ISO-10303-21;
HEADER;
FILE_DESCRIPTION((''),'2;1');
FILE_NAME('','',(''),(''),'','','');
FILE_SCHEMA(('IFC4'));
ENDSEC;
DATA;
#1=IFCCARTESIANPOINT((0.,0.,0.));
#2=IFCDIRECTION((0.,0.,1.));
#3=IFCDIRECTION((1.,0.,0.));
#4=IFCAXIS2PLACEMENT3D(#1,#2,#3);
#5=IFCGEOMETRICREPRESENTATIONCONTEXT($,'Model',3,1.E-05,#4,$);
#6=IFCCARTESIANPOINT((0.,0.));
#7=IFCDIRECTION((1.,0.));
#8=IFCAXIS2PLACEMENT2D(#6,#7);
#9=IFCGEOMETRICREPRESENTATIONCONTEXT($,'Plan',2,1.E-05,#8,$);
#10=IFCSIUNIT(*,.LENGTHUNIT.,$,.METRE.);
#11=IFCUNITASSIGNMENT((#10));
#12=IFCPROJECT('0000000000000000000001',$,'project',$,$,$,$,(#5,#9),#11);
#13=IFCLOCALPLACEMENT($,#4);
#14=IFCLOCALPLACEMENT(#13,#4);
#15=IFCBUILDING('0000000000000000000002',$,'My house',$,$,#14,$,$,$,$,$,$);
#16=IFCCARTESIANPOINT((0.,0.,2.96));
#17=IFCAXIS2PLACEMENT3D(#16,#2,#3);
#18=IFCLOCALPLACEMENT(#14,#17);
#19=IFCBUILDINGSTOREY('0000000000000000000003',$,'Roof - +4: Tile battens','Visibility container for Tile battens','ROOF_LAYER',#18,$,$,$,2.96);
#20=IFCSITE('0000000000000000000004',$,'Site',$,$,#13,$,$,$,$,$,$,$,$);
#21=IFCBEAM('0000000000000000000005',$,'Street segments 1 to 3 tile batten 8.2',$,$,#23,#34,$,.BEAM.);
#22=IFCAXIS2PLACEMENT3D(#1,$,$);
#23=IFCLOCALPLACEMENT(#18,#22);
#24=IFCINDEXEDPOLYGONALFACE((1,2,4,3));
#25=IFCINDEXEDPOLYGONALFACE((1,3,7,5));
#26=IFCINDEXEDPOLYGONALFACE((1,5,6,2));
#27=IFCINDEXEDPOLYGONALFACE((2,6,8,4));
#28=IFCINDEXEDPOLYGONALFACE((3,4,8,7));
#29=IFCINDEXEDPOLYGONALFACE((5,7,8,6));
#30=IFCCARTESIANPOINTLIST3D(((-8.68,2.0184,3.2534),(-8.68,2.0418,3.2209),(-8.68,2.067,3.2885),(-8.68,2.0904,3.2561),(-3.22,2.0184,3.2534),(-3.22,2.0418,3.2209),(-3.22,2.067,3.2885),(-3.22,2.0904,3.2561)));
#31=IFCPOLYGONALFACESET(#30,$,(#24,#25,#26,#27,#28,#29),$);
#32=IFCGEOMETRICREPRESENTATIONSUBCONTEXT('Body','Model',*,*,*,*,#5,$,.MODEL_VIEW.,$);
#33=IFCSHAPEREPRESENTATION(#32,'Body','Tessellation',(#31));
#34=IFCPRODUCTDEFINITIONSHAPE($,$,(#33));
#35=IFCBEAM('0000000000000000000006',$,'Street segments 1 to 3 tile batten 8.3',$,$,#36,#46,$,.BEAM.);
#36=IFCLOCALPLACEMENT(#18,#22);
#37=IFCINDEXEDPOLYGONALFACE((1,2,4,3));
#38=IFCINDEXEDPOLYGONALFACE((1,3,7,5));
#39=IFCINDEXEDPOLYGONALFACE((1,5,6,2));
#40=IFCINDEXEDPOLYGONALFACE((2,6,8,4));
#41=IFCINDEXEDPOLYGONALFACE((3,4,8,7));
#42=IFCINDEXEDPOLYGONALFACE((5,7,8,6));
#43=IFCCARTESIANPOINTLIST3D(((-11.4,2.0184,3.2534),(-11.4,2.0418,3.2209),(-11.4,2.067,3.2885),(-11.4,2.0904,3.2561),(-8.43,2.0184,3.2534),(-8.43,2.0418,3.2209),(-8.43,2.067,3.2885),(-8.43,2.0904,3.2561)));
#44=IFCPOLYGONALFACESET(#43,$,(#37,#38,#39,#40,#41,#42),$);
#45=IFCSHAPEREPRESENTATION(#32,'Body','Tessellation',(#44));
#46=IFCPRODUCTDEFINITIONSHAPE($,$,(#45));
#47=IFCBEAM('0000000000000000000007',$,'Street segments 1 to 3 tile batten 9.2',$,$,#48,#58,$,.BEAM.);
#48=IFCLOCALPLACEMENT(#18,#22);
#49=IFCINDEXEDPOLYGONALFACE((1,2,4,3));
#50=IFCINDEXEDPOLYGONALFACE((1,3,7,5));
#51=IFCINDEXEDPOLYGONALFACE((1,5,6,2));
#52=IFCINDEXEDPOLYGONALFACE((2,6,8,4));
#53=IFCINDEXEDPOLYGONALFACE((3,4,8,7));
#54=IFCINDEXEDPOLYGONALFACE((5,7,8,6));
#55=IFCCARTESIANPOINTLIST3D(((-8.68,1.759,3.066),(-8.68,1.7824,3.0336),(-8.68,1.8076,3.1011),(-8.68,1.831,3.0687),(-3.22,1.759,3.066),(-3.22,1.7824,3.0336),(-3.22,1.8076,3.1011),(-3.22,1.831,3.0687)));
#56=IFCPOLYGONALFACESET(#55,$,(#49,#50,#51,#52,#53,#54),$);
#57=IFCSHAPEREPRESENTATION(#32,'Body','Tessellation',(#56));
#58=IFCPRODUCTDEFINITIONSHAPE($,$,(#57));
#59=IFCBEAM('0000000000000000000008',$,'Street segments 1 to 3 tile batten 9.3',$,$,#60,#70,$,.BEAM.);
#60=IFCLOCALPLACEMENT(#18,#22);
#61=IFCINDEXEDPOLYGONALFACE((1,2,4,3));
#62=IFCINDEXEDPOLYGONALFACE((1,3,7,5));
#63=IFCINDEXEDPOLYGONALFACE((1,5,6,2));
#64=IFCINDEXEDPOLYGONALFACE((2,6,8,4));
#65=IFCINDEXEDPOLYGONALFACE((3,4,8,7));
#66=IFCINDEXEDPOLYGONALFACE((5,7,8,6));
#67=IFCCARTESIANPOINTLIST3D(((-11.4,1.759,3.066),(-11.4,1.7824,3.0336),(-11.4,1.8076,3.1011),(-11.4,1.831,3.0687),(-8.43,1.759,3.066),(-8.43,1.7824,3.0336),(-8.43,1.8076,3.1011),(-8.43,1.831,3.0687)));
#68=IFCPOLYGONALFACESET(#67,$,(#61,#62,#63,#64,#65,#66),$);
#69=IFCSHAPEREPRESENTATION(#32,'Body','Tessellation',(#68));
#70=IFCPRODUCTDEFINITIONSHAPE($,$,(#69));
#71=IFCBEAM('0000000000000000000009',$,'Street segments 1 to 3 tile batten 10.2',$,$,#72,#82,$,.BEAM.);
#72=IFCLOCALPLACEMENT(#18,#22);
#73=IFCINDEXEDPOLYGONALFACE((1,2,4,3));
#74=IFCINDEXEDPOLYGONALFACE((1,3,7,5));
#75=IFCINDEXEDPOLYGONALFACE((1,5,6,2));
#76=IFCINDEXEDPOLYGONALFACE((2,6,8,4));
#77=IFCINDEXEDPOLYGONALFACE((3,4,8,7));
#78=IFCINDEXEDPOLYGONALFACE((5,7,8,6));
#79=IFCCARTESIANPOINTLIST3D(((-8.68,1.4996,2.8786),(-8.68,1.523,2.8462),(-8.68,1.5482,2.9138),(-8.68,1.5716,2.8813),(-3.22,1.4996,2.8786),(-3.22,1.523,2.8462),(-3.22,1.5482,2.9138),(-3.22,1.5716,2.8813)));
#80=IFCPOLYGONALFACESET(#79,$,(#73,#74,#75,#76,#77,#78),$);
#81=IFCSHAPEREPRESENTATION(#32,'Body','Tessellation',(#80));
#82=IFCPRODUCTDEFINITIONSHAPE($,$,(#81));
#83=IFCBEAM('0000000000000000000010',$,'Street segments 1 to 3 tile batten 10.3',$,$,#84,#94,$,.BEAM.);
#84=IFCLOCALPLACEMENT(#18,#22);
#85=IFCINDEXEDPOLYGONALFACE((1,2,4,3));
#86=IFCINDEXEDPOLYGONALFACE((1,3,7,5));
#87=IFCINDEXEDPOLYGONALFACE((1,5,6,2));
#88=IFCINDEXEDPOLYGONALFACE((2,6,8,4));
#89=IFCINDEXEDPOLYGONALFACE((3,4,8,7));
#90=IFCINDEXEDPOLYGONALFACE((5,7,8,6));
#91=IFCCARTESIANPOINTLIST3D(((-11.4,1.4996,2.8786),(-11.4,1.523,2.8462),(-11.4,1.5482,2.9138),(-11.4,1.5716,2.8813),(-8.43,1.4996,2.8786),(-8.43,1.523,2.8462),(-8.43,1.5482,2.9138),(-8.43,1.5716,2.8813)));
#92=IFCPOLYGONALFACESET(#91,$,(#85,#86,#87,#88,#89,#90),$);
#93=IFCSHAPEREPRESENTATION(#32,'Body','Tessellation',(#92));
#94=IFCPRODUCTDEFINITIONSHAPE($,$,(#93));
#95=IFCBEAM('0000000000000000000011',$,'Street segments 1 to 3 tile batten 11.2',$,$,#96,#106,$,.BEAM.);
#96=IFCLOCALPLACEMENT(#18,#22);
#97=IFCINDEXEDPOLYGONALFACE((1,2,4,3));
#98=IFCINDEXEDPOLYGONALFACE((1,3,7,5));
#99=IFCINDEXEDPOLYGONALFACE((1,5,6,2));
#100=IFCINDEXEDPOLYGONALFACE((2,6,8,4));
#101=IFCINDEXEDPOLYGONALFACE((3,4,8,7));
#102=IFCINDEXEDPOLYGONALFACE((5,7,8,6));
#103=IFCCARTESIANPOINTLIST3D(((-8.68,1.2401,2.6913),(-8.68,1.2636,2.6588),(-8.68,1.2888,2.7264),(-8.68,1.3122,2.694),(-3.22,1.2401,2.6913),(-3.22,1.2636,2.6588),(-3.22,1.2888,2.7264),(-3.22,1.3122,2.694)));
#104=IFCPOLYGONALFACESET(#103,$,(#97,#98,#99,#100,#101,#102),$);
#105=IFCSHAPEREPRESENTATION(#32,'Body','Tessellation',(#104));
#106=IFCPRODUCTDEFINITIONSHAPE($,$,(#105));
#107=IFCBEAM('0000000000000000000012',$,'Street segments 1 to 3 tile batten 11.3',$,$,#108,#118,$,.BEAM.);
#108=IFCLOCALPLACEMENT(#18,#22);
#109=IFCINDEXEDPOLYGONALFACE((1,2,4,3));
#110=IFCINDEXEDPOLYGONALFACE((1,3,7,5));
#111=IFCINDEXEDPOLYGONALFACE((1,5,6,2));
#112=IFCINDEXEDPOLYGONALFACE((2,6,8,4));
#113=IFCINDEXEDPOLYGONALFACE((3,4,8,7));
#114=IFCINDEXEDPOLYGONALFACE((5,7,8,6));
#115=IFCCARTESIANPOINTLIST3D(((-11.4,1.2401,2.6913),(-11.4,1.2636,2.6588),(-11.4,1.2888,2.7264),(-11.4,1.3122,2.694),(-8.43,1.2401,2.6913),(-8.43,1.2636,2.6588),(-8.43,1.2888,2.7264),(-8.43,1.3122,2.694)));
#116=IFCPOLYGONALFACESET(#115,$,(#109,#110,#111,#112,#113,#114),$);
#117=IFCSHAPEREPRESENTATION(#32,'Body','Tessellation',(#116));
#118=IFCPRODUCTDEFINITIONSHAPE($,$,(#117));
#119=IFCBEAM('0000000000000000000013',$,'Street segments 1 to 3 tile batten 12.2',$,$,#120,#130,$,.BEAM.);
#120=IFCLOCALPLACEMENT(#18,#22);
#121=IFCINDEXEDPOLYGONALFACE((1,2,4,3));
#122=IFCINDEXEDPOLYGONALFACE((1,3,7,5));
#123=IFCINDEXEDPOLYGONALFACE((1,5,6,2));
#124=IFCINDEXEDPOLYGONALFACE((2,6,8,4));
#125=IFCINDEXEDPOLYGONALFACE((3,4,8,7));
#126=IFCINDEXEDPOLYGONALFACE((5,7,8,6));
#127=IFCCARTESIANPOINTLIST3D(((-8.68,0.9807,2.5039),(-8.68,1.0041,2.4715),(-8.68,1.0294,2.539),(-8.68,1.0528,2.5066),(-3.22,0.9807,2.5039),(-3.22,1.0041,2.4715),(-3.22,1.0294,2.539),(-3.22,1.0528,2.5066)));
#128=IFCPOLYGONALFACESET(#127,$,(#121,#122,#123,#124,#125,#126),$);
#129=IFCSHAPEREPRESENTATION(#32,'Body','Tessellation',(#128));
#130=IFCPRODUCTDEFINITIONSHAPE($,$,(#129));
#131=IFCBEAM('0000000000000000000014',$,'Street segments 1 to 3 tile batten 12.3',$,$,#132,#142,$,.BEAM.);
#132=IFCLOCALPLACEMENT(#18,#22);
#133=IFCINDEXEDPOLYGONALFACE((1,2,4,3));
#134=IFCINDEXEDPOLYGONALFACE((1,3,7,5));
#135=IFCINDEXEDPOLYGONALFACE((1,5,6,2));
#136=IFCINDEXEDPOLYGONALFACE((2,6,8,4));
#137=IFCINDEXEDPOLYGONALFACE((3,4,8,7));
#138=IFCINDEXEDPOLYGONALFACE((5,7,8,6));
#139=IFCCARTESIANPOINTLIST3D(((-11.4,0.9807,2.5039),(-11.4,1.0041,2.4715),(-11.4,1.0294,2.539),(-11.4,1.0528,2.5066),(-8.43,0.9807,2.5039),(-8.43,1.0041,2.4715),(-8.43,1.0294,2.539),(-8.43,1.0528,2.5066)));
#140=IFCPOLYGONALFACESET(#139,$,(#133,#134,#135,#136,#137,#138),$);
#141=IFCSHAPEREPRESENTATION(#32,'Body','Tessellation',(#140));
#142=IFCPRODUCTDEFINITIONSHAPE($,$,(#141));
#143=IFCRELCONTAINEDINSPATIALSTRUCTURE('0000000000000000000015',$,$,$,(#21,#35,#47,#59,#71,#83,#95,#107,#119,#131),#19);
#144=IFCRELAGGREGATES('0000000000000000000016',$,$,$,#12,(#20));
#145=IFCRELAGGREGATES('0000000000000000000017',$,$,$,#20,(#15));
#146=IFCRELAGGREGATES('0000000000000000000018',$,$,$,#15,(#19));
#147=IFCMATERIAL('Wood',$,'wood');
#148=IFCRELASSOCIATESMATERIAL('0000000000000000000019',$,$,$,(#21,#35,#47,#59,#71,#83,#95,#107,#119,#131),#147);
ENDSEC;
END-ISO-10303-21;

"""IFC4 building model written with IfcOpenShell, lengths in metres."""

from ifc_helpers import new_model, si_unit, frame, origin_with_axes, origin_2d_with_axis, place, context, subcontext, project, spatial, rectangle, extrude, clip, halfspace, source, transform, mapped, material, element, save


model = new_model("IFC4")

# Units and contexts
model_context = context("Model", 3, precision=1e-05, world=origin_with_axes())
plan_context = context("Plan", 2, precision=1e-05, world=origin_2d_with_axis())
body_context = subcontext(model_context, "Body", "Model", "MODEL_VIEW")
ifc_project = project(units=[si_unit("LENGTHUNIT", "METRE")], contexts=[model_context, plan_context])

# Site, building, storey
site_placement = place(None, origin_with_axes())
site = spatial("IfcSite", under=ifc_project, at=site_placement, Name="Site")
building_placement = place(site_placement, origin_with_axes())
building = spatial("IfcBuilding", under=site, at=building_placement, Name="My house")
storey_placement = place(building_placement, frame((0.0, 0.0, 2.96), z_axis=(0.0, 0.0, 1.0), x_axis=(1.0, 0.0, 0.0)))
storey = spatial("IfcBuildingStorey", under=building, at=storey_placement, Name="Roof - +4: Tile battens", Description="Visibility container for Tile battens", ObjectType="ROOF_LAYER", Elevation=2.96)

# Beams
ifc_material = material(Name="Wood", Category="wood")
shared_shape_1 = source(origin_with_axes(), body_context, "Body", "Clipping", [
    clip(clip(extrude(rectangle(XDim=0.06, YDim=0.04), frame((0.0, 0.0, 0.0), z_axis=(1.0, 0.0, 0.0), x_axis=(0.0, 1.0, 0.0)), (0.0, 0.0, 1.0), 5.46), halfspace(frame((-3.22, -2.0616, -6.1772), z_axis=(0.0, 0.810664, -0.585512), x_axis=(1.0, 0.0, 0.0)), False)), halfspace(frame((-3.22, -5.9122, -3.396), z_axis=(0.0, -0.810664, 0.585512), x_axis=(-1.0, 0.0, 0.0)), False)),
])
beam_1_placement = place(storey_placement, frame((-3.22, 2.0544, 3.2547), z_axis=(0.0, -0.585512, 0.810664), x_axis=(1.0, 0.0, 0.0)))
element("IfcBeam", 1, at=beam_1_placement, inside=storey, material=ifc_material, Name="Street segments 1 to 3 tile batten 8.2", PredefinedType="BEAM", context=body_context, shape_type="MappedRepresentation", body=[
    mapped(shared_shape_1, transform((0.0, 0.0, 0.0), x_axis=(-1.0, 0.0, 0.0), y_axis=(0.0, 1.0, 0.0), z_axis=(0.0, 0.0, 1.0), scale=1.0)),
])
shared_shape_2 = source(origin_with_axes(), body_context, "Body", "Clipping", [
    clip(clip(extrude(rectangle(XDim=0.06, YDim=0.04), frame((0.0, 0.0, 0.0), z_axis=(1.0, 0.0, 0.0), x_axis=(0.0, 1.0, 0.0)), (0.0, 0.0, 1.0), 2.97), halfspace(frame((-8.43, -2.0616, -6.1772), z_axis=(0.0, 0.810664, -0.585512), x_axis=(1.0, 0.0, 0.0)), False)), halfspace(frame((-8.43, -5.9122, -3.396), z_axis=(0.0, -0.810664, 0.585512), x_axis=(-1.0, 0.0, 0.0)), False)),
])
beam_2_placement = place(storey_placement, frame((-8.43, 2.0544, 3.2547), z_axis=(0.0, -0.585512, 0.810664), x_axis=(1.0, 0.0, 0.0)))
element("IfcBeam", 2, at=beam_2_placement, inside=storey, material=ifc_material, Name="Street segments 1 to 3 tile batten 8.3", PredefinedType="BEAM", context=body_context, shape_type="MappedRepresentation", body=[
    mapped(shared_shape_2, transform((0.0, 0.0, 0.0), x_axis=(-1.0, 0.0, 0.0), y_axis=(0.0, 1.0, 0.0), z_axis=(0.0, 0.0, 1.0), scale=1.0)),
])
shared_shape_3 = source(origin_with_axes(), body_context, "Body", "Clipping", [
    clip(clip(extrude(rectangle(XDim=0.06, YDim=0.04), frame((0.0, 0.0, 0.0), z_axis=(1.0, 0.0, 0.0), x_axis=(0.0, 1.0, 0.0)), (0.0, 0.0, 1.0), 5.46), halfspace(frame((-3.22, -1.7416, -6.1772), z_axis=(0.0, 0.810664, -0.585512), x_axis=(1.0, 0.0, 0.0)), False)), halfspace(frame((-3.22, -5.5922, -3.396), z_axis=(0.0, -0.810664, 0.585512), x_axis=(-1.0, 0.0, 0.0)), False)),
])
beam_3_placement = place(storey_placement, frame((-3.22, 1.795, 3.0673), z_axis=(0.0, -0.585512, 0.810664), x_axis=(1.0, 0.0, 0.0)))
element("IfcBeam", 3, at=beam_3_placement, inside=storey, material=ifc_material, Name="Street segments 1 to 3 tile batten 9.2", PredefinedType="BEAM", context=body_context, shape_type="MappedRepresentation", body=[
    mapped(shared_shape_3, transform((0.0, 0.0, 0.0), x_axis=(-1.0, 0.0, 0.0), y_axis=(0.0, 1.0, 0.0), z_axis=(0.0, 0.0, 1.0), scale=1.0)),
])
shared_shape_4 = source(origin_with_axes(), body_context, "Body", "Clipping", [
    clip(clip(extrude(rectangle(XDim=0.06, YDim=0.04), frame((0.0, 0.0, 0.0), z_axis=(1.0, 0.0, 0.0), x_axis=(0.0, 1.0, 0.0)), (0.0, 0.0, 1.0), 2.97), halfspace(frame((-8.43, -1.7416, -6.1772), z_axis=(0.0, 0.810664, -0.585512), x_axis=(1.0, 0.0, 0.0)), False)), halfspace(frame((-8.43, -5.5922, -3.396), z_axis=(0.0, -0.810664, 0.585512), x_axis=(-1.0, 0.0, 0.0)), False)),
])
beam_4_placement = place(storey_placement, frame((-8.43, 1.795, 3.0673), z_axis=(0.0, -0.585512, 0.810664), x_axis=(1.0, 0.0, 0.0)))
element("IfcBeam", 4, at=beam_4_placement, inside=storey, material=ifc_material, Name="Street segments 1 to 3 tile batten 9.3", PredefinedType="BEAM", context=body_context, shape_type="MappedRepresentation", body=[
    mapped(shared_shape_4, transform((0.0, 0.0, 0.0), x_axis=(-1.0, 0.0, 0.0), y_axis=(0.0, 1.0, 0.0), z_axis=(0.0, 0.0, 1.0), scale=1.0)),
])
shared_shape_5 = source(origin_with_axes(), body_context, "Body", "Clipping", [
    clip(clip(extrude(rectangle(XDim=0.06, YDim=0.04), frame((0.0, 0.0, 0.0), z_axis=(1.0, 0.0, 0.0), x_axis=(0.0, 1.0, 0.0)), (0.0, 0.0, 1.0), 5.46), halfspace(frame((-3.22, -1.4216, -6.1772), z_axis=(0.0, 0.810664, -0.585512), x_axis=(1.0, 0.0, 0.0)), False)), halfspace(frame((-3.22, -5.2722, -3.396), z_axis=(0.0, -0.810664, 0.585512), x_axis=(-1.0, 0.0, 0.0)), False)),
])
beam_5_placement = place(storey_placement, frame((-3.22, 1.5356, 2.88), z_axis=(0.0, -0.585512, 0.810664), x_axis=(1.0, 0.0, 0.0)))
element("IfcBeam", 5, at=beam_5_placement, inside=storey, material=ifc_material, Name="Street segments 1 to 3 tile batten 10.2", PredefinedType="BEAM", context=body_context, shape_type="MappedRepresentation", body=[
    mapped(shared_shape_5, transform((0.0, 0.0, 0.0), x_axis=(-1.0, 0.0, 0.0), y_axis=(0.0, 1.0, 0.0), z_axis=(0.0, 0.0, 1.0), scale=1.0)),
])
shared_shape_6 = source(origin_with_axes(), body_context, "Body", "Clipping", [
    clip(clip(extrude(rectangle(XDim=0.06, YDim=0.04), frame((0.0, 0.0, 0.0), z_axis=(1.0, 0.0, 0.0), x_axis=(0.0, 1.0, 0.0)), (0.0, 0.0, 1.0), 2.97), halfspace(frame((-8.43, -1.4216, -6.1772), z_axis=(0.0, 0.810664, -0.585512), x_axis=(1.0, 0.0, 0.0)), False)), halfspace(frame((-8.43, -5.2722, -3.396), z_axis=(0.0, -0.810664, 0.585512), x_axis=(-1.0, 0.0, 0.0)), False)),
])
beam_6_placement = place(storey_placement, frame((-8.43, 1.5356, 2.88), z_axis=(0.0, -0.585512, 0.810664), x_axis=(1.0, 0.0, 0.0)))
element("IfcBeam", 6, at=beam_6_placement, inside=storey, material=ifc_material, Name="Street segments 1 to 3 tile batten 10.3", PredefinedType="BEAM", context=body_context, shape_type="MappedRepresentation", body=[
    mapped(shared_shape_6, transform((0.0, 0.0, 0.0), x_axis=(-1.0, 0.0, 0.0), y_axis=(0.0, 1.0, 0.0), z_axis=(0.0, 0.0, 1.0), scale=1.0)),
])
shared_shape_7 = source(origin_with_axes(), body_context, "Body", "Clipping", [
    clip(clip(extrude(rectangle(XDim=0.06, YDim=0.04), frame((0.0, 0.0, 0.0), z_axis=(1.0, 0.0, 0.0), x_axis=(0.0, 1.0, 0.0)), (0.0, 0.0, 1.0), 5.46), halfspace(frame((-3.22, -1.1016, -6.1772), z_axis=(0.0, 0.810664, -0.585512), x_axis=(1.0, 0.0, 0.0)), False)), halfspace(frame((-3.22, -4.9522, -3.396), z_axis=(0.0, -0.810664, 0.585512), x_axis=(-1.0, 0.0, 0.0)), False)),
])
beam_7_placement = place(storey_placement, frame((-3.22, 1.2762, 2.6926), z_axis=(0.0, -0.585512, 0.810664), x_axis=(1.0, 0.0, 0.0)))
element("IfcBeam", 7, at=beam_7_placement, inside=storey, material=ifc_material, Name="Street segments 1 to 3 tile batten 11.2", PredefinedType="BEAM", context=body_context, shape_type="MappedRepresentation", body=[
    mapped(shared_shape_7, transform((0.0, 0.0, 0.0), x_axis=(-1.0, 0.0, 0.0), y_axis=(0.0, 1.0, 0.0), z_axis=(0.0, 0.0, 1.0), scale=1.0)),
])
shared_shape_8 = source(origin_with_axes(), body_context, "Body", "Clipping", [
    clip(clip(extrude(rectangle(XDim=0.06, YDim=0.04), frame((0.0, 0.0, 0.0), z_axis=(1.0, 0.0, 0.0), x_axis=(0.0, 1.0, 0.0)), (0.0, 0.0, 1.0), 2.97), halfspace(frame((-8.43, -1.1016, -6.1772), z_axis=(0.0, 0.810664, -0.585512), x_axis=(1.0, 0.0, 0.0)), False)), halfspace(frame((-8.43, -4.9522, -3.396), z_axis=(0.0, -0.810664, 0.585512), x_axis=(-1.0, 0.0, 0.0)), False)),
])
beam_8_placement = place(storey_placement, frame((-8.43, 1.2762, 2.6926), z_axis=(0.0, -0.585512, 0.810664), x_axis=(1.0, 0.0, 0.0)))
element("IfcBeam", 8, at=beam_8_placement, inside=storey, material=ifc_material, Name="Street segments 1 to 3 tile batten 11.3", PredefinedType="BEAM", context=body_context, shape_type="MappedRepresentation", body=[
    mapped(shared_shape_8, transform((0.0, 0.0, 0.0), x_axis=(-1.0, 0.0, 0.0), y_axis=(0.0, 1.0, 0.0), z_axis=(0.0, 0.0, 1.0), scale=1.0)),
])
shared_shape_9 = source(origin_with_axes(), body_context, "Body", "Clipping", [
    clip(clip(extrude(rectangle(XDim=0.06, YDim=0.04), frame((0.0, 0.0, 0.0), z_axis=(1.0, 0.0, 0.0), x_axis=(0.0, 1.0, 0.0)), (0.0, 0.0, 1.0), 5.46), halfspace(frame((-3.22, -0.7816, -6.1772), z_axis=(0.0, 0.810664, -0.585512), x_axis=(1.0, 0.0, 0.0)), False)), halfspace(frame((-3.22, -4.6322, -3.396), z_axis=(0.0, -0.810664, 0.585512), x_axis=(-1.0, 0.0, 0.0)), False)),
])
beam_9_placement = place(storey_placement, frame((-3.22, 1.0168, 2.5053), z_axis=(0.0, -0.585512, 0.810664), x_axis=(1.0, 0.0, 0.0)))
element("IfcBeam", 9, at=beam_9_placement, inside=storey, material=ifc_material, Name="Street segments 1 to 3 tile batten 12.2", PredefinedType="BEAM", context=body_context, shape_type="MappedRepresentation", body=[
    mapped(shared_shape_9, transform((0.0, 0.0, 0.0), x_axis=(-1.0, 0.0, 0.0), y_axis=(0.0, 1.0, 0.0), z_axis=(0.0, 0.0, 1.0), scale=1.0)),
])
shared_shape_10 = source(origin_with_axes(), body_context, "Body", "Clipping", [
    clip(clip(extrude(rectangle(XDim=0.06, YDim=0.04), frame((0.0, 0.0, 0.0), z_axis=(1.0, 0.0, 0.0), x_axis=(0.0, 1.0, 0.0)), (0.0, 0.0, 1.0), 2.97), halfspace(frame((-8.43, -0.7816, -6.1772), z_axis=(0.0, 0.810664, -0.585512), x_axis=(1.0, 0.0, 0.0)), False)), halfspace(frame((-8.43, -4.6322, -3.396), z_axis=(0.0, -0.810664, 0.585512), x_axis=(-1.0, 0.0, 0.0)), False)),
])
beam_10_placement = place(storey_placement, frame((-8.43, 1.0168, 2.5053), z_axis=(0.0, -0.585512, 0.810664), x_axis=(1.0, 0.0, 0.0)))
element("IfcBeam", 10, at=beam_10_placement, inside=storey, material=ifc_material, Name="Street segments 1 to 3 tile batten 12.3", PredefinedType="BEAM", context=body_context, shape_type="MappedRepresentation", body=[
    mapped(shared_shape_10, transform((0.0, 0.0, 0.0), x_axis=(-1.0, 0.0, 0.0), y_axis=(0.0, 1.0, 0.0), z_axis=(0.0, 0.0, 1.0), scale=1.0)),
])

save(model, "model.ifc")
